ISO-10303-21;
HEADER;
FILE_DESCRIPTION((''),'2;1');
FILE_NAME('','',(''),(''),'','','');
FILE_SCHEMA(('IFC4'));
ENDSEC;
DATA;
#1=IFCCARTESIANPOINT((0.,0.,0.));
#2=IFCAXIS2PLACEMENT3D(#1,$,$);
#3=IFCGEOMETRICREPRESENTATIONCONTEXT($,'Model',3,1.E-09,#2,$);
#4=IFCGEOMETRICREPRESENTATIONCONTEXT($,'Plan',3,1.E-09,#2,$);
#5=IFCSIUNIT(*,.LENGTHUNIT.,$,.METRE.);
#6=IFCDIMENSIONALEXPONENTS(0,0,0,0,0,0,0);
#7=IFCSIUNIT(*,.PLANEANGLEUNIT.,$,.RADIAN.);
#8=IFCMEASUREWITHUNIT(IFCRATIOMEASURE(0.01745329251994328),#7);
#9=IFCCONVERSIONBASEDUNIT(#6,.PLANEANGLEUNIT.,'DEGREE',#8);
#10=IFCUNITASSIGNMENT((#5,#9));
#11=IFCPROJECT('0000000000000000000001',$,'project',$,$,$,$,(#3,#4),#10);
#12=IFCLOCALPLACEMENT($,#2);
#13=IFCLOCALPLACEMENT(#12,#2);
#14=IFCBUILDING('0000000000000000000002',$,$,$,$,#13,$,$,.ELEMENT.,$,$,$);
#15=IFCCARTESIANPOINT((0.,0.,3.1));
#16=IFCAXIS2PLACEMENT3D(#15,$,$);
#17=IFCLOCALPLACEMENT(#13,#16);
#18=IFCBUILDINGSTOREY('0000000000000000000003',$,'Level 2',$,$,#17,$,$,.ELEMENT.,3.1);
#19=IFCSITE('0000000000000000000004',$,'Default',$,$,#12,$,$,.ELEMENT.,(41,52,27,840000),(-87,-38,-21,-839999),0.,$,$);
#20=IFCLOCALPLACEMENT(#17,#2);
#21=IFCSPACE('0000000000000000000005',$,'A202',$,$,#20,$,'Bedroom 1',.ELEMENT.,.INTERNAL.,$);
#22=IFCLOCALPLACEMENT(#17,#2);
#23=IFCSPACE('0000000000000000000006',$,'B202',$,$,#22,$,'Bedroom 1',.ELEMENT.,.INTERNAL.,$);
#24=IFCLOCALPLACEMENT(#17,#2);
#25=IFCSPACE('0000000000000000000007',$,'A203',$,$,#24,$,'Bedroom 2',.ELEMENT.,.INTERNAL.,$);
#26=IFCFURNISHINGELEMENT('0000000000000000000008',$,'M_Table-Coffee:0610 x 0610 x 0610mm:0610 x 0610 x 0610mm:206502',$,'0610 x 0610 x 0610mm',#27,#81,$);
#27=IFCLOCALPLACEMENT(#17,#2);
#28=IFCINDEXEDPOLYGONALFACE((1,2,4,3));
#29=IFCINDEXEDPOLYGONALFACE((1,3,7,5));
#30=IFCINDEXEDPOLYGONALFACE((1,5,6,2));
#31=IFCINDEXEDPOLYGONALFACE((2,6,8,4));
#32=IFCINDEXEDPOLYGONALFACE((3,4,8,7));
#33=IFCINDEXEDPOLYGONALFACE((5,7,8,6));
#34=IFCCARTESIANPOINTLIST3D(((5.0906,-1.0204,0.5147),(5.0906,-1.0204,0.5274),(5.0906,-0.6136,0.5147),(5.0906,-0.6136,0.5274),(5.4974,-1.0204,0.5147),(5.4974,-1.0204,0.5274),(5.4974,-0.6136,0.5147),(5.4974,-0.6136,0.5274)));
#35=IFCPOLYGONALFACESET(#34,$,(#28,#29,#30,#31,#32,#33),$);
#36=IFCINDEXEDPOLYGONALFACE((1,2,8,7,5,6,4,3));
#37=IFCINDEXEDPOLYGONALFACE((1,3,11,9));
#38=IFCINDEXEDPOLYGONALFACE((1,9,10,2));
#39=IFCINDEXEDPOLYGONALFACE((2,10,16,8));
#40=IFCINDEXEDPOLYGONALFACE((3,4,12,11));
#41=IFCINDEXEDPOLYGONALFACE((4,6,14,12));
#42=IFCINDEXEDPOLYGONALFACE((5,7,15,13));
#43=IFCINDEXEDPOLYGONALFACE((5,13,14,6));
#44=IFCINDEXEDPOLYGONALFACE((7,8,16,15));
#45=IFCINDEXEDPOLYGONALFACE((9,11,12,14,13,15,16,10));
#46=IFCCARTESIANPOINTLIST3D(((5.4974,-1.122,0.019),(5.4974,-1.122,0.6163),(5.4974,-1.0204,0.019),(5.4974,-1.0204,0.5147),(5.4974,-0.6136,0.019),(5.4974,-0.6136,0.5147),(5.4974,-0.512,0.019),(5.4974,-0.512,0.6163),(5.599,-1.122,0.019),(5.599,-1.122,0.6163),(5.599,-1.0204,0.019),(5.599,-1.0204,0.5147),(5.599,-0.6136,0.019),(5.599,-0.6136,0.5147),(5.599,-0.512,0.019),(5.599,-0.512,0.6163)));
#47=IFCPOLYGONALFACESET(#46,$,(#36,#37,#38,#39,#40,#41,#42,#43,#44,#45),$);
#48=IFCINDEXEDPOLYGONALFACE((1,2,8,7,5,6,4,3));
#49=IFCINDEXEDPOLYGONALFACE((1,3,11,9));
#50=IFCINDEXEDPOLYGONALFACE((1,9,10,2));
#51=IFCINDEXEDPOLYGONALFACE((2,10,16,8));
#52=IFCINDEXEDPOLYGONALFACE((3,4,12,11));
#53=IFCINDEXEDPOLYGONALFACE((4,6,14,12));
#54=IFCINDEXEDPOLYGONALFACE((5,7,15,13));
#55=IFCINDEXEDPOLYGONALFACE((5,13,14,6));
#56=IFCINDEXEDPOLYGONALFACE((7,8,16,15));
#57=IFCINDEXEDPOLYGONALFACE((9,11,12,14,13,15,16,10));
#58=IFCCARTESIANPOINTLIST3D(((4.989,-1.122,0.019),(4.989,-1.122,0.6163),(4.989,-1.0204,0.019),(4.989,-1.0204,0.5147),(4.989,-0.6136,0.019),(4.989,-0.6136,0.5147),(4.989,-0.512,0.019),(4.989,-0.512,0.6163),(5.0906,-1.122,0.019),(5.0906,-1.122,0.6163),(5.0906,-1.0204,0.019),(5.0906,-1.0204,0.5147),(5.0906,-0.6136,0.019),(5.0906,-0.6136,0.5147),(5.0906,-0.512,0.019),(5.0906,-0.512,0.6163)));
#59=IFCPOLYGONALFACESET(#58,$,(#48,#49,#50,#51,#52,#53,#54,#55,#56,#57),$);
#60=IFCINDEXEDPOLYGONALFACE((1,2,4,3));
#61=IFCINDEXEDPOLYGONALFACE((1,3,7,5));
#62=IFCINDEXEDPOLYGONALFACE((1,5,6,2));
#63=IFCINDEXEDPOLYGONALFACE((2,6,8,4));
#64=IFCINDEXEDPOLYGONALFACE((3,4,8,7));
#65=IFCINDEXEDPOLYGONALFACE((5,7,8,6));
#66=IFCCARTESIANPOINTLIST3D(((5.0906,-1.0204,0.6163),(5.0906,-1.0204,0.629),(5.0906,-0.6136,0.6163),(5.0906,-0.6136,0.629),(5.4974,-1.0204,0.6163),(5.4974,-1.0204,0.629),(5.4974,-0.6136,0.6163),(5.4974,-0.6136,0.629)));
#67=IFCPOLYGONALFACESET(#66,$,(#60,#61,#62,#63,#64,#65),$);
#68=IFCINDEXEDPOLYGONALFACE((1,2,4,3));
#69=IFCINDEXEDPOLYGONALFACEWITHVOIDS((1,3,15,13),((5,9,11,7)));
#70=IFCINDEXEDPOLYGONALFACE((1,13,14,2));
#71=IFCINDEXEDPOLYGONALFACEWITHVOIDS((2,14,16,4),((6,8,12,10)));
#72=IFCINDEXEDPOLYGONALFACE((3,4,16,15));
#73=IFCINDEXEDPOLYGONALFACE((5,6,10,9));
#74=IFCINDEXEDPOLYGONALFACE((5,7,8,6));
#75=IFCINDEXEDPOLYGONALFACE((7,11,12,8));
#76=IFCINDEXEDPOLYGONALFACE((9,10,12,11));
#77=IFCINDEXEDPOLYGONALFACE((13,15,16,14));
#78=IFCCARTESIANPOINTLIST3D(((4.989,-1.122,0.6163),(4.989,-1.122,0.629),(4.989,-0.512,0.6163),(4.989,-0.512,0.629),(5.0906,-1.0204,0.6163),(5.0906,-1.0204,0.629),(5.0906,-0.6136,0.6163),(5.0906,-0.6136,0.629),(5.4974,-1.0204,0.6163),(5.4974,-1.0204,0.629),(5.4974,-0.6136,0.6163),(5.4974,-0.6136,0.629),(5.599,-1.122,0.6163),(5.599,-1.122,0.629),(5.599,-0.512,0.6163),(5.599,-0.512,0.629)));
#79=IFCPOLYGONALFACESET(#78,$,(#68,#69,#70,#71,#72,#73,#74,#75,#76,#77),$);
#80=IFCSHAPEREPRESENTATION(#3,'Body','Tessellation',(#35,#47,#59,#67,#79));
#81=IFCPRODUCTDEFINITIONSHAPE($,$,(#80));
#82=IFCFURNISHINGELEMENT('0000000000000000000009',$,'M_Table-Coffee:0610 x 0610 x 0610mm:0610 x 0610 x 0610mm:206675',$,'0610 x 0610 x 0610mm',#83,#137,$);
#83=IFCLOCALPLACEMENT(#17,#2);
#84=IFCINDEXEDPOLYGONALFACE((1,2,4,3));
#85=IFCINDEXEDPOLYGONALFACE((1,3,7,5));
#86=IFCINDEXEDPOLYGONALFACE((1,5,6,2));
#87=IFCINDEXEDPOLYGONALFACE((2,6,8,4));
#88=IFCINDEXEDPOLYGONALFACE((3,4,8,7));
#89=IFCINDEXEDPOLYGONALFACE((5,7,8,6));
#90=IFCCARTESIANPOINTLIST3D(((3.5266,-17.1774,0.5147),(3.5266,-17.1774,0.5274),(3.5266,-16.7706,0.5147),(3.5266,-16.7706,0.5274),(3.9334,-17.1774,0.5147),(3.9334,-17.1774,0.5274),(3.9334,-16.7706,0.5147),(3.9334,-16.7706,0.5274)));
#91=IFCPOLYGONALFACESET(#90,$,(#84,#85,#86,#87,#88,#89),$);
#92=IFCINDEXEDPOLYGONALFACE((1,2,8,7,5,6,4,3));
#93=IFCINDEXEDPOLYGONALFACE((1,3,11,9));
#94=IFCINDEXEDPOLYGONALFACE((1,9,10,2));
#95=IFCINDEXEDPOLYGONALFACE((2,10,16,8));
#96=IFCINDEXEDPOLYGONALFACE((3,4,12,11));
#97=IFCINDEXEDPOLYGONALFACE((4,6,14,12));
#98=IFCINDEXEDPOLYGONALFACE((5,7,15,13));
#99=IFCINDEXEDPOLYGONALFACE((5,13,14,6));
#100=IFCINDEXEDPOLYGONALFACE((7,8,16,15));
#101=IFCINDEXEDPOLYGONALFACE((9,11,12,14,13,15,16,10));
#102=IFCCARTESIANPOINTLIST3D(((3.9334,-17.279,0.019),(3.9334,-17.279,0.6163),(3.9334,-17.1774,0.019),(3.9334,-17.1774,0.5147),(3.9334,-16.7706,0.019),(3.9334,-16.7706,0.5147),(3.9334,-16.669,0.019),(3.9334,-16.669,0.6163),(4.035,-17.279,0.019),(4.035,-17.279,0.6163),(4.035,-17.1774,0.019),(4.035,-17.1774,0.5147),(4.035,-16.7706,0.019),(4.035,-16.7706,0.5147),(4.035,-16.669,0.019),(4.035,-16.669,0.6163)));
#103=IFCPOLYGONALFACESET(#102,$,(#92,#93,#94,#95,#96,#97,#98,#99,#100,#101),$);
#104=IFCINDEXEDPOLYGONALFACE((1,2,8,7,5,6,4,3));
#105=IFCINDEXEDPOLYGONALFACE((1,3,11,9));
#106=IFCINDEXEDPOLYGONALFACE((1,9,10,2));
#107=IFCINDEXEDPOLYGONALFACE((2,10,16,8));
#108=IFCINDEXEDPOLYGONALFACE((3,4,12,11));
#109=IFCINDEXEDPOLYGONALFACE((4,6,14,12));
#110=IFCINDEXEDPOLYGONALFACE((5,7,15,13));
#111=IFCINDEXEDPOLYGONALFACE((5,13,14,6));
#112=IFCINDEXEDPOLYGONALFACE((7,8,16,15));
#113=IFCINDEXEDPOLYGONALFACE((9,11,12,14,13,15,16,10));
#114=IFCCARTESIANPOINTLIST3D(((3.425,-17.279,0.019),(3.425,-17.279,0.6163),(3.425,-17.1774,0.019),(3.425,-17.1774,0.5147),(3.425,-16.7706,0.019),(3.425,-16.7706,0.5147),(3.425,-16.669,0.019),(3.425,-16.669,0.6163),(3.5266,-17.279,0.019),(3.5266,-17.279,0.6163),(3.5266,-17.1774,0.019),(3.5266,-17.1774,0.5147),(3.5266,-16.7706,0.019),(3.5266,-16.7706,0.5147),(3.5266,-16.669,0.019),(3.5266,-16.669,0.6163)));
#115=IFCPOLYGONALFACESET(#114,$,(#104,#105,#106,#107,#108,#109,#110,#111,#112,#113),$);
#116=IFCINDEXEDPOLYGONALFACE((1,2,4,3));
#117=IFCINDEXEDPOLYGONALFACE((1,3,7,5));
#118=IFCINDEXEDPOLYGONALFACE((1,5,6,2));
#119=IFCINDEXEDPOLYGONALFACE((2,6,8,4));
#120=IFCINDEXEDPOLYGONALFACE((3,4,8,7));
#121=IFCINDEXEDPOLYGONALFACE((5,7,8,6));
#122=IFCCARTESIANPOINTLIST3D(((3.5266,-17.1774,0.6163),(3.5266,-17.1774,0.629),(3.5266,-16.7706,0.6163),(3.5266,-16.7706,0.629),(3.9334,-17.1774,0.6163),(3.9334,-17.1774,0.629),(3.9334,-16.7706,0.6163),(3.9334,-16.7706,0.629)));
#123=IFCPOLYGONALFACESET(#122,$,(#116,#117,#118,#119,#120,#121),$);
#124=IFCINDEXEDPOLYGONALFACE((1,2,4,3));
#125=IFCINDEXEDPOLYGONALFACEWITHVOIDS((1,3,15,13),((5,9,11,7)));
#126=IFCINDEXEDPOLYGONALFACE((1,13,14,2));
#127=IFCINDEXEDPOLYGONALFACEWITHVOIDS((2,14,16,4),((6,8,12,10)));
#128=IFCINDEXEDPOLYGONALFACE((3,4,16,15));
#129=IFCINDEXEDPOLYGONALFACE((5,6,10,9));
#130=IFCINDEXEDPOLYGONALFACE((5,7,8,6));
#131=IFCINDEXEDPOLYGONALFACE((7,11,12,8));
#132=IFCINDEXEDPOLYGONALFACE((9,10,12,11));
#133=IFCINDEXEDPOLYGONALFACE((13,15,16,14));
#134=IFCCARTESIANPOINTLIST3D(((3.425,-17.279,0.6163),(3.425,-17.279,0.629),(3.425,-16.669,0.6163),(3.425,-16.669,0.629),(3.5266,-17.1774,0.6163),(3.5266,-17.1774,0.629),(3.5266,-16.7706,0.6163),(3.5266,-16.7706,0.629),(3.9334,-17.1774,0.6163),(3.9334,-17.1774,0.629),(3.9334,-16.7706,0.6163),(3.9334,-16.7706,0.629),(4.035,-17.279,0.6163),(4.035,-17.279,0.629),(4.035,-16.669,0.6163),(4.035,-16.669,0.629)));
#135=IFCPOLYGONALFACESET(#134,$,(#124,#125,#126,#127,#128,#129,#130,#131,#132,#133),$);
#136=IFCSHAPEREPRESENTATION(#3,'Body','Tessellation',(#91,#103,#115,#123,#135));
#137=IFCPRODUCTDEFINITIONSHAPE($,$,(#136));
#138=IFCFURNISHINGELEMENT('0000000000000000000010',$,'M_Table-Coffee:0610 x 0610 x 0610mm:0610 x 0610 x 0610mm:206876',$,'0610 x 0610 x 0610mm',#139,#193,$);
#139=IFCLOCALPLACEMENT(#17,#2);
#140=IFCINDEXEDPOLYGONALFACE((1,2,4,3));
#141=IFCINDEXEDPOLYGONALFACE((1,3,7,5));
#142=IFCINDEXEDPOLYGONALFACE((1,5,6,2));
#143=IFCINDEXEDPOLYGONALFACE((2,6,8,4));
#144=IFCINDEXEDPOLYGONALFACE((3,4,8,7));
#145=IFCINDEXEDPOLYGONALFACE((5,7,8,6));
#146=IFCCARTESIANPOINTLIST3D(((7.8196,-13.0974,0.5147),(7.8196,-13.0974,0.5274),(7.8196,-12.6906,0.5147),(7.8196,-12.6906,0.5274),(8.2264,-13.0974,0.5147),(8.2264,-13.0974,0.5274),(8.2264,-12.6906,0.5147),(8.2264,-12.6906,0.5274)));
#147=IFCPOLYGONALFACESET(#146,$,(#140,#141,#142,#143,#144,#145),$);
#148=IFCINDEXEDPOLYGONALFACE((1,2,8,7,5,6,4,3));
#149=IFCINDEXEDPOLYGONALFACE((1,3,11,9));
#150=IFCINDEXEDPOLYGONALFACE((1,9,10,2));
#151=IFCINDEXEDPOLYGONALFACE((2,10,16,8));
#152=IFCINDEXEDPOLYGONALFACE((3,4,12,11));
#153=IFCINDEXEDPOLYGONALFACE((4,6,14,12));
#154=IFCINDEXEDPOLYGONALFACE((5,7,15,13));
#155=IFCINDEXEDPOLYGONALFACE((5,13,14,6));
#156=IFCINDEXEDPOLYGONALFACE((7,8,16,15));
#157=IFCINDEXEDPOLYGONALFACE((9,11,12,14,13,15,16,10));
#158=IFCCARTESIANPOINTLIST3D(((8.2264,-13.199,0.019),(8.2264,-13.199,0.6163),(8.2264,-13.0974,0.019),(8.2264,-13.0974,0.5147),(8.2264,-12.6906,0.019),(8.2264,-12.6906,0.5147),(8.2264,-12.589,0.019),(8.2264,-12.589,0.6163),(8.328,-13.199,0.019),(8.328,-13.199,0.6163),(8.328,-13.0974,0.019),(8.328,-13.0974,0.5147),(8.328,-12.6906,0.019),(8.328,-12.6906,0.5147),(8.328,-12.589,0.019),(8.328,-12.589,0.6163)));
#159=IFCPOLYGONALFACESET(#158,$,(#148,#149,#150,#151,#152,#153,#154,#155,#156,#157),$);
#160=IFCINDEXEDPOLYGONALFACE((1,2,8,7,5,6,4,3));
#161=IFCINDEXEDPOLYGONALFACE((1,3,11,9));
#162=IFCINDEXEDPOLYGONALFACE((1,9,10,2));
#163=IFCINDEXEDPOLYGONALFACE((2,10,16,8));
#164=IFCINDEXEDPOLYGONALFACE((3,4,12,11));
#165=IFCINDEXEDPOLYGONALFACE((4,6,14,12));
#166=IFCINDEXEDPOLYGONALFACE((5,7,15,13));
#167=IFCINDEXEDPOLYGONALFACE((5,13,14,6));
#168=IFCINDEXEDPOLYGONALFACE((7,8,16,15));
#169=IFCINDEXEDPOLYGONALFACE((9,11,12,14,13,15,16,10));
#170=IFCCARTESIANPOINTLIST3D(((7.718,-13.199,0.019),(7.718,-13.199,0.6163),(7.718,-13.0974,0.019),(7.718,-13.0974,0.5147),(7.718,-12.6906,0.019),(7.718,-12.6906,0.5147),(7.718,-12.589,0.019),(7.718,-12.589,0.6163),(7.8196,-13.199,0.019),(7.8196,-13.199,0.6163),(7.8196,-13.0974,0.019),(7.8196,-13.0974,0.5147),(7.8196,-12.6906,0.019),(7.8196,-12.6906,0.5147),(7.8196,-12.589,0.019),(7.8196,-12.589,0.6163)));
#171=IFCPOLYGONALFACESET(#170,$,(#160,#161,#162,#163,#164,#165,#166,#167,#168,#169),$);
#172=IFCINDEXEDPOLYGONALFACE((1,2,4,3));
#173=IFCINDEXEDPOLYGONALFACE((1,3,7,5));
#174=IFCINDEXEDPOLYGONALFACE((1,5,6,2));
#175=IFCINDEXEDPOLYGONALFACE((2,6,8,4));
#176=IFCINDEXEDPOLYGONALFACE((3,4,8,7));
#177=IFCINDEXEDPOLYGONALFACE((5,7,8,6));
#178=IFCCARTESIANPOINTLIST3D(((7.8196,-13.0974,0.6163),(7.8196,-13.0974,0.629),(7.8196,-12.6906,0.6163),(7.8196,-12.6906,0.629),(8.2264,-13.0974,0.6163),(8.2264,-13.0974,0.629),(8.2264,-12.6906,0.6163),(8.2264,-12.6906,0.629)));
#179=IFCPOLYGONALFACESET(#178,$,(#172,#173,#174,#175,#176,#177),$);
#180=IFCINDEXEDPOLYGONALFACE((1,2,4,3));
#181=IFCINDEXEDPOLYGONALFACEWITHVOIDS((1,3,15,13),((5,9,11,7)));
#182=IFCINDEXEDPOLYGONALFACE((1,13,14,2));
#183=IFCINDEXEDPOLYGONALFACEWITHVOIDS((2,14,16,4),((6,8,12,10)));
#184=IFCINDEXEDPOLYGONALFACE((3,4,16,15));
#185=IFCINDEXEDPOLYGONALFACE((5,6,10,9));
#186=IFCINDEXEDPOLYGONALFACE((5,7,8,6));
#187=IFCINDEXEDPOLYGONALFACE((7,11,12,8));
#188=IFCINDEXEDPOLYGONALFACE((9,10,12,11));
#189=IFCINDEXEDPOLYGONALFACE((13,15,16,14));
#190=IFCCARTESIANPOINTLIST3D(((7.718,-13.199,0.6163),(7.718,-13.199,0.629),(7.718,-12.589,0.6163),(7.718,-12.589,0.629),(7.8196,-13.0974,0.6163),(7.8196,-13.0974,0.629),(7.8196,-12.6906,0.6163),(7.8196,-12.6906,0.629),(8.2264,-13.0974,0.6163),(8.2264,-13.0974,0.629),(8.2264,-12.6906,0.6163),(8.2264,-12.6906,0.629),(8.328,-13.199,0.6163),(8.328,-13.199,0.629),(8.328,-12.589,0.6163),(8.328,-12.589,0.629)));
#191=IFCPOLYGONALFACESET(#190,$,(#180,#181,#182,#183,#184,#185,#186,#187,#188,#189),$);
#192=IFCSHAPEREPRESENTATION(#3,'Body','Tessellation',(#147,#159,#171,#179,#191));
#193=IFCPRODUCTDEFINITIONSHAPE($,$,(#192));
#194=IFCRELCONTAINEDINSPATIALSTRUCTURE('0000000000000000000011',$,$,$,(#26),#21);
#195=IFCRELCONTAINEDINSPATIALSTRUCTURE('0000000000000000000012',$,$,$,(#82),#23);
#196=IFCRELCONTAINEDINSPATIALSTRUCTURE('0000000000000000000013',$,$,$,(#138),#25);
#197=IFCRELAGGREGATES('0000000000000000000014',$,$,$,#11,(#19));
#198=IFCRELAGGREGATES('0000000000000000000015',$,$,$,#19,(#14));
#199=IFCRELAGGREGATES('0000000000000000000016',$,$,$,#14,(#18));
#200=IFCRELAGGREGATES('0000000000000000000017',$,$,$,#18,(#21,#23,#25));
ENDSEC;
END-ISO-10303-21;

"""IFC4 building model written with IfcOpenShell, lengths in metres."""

from ifc_helpers import new_model, entity, si_unit, converted_unit, frame, origin, origin_2d_with_axis, place, context, project, spatial, polyline, rectangle, outline, extrude, source, transform, mapped, element, save


model = new_model("IFC4")

# Units and contexts
model_context = context("Model", 3, precision=1e-09, world=origin())
plan_context = context("Plan", 3, precision=1e-09, world=origin())
ifc_project = project(units=[si_unit("LENGTHUNIT", "METRE"), converted_unit("PLANEANGLEUNIT", "DEGREE", entity("IfcRatioMeasure", 0.01745329251994328), si_unit("PLANEANGLEUNIT", "RADIAN"), dimensions=[0, 0, 0, 0, 0, 0, 0])], contexts=[model_context, plan_context])

# Site, building, storey
site_placement = place(None, origin())
site = spatial("IfcSite", under=ifc_project, at=site_placement, Name="Default", CompositionType="ELEMENT", RefLatitude=(41, 52, 27, 840000), RefLongitude=(-87, -38, -21, -839999), RefElevation=0.0)
building_placement = place(site_placement, origin())
building = spatial("IfcBuilding", under=site, at=building_placement, CompositionType="ELEMENT")
storey_placement = place(building_placement, frame((0.0, 0.0, 3.1)))
storey = spatial("IfcBuildingStorey", under=building, at=storey_placement, Name="Level 2", CompositionType="ELEMENT", Elevation=3.1)

# Shared definitions
shared_shape = source(origin(), model_context, "Body", "SweptSolid", [
    extrude(rectangle(XDim=0.4068, YDim=0.4068, at=origin_2d_with_axis()), frame((0.0183, 0.0952, 0.4957), z_axis=(0.0, 0.0, 1.0), x_axis=(-1.0, 0.0, 0.0)), (0.0, 0.0, 1.0), 0.0127),
    extrude(outline(polyline([(-0.2732, -0.305), (0.324, -0.305), (0.324, 0.305), (-0.2732, 0.305), (-0.2732, 0.2034), (0.2225, 0.2034), (0.2225, -0.2034), (-0.2732, -0.2034), (-0.2732, -0.305)])), frame((0.2217, 0.0952, 0.2732), z_axis=(1.0, 0.0, 0.0), x_axis=(0.0, 0.0, 1.0)), (0.0, 0.0, 1.0), 0.1016),
    extrude(outline(polyline([(-0.305, -0.3241), (0.305, -0.3241), (0.305, 0.2733), (0.2034, 0.2733), (0.2034, -0.2224), (-0.2034, -0.2224), (-0.2034, 0.2733), (-0.305, 0.2733), (-0.305, -0.3241)])), frame((-0.2867, 0.0952, 0.2733), z_axis=(1.0, 0.0, 0.0), x_axis=(0.0, -1.0, 0.0)), (0.0, 0.0, 1.0), 0.1016),
    extrude(rectangle(XDim=0.4068, YDim=0.4068, at=origin_2d_with_axis()), frame((0.0183, 0.0952, 0.5973), z_axis=(0.0, 0.0, 1.0), x_axis=(-1.0, 0.0, 0.0)), (0.0, 0.0, 1.0), 0.0127),
    extrude(outline(polyline([(-0.305, -0.305), (0.305, -0.305), (0.305, 0.305), (-0.305, 0.305), (-0.305, -0.305)]), holes=[polyline([(-0.2034, -0.2034), (-0.2034, 0.2034), (0.2034, 0.2034), (0.2034, -0.2034), (-0.2034, -0.2034)])]), frame((0.0183, 0.0952, 0.5973), z_axis=(0.0, 0.0, 1.0), x_axis=(-1.0, 0.0, 0.0)), (0.0, 0.0, 1.0), 0.0127),
])

# Shared definitions
space_1_placement = place(storey_placement, origin())
space_1 = spatial("IfcSpace", under=storey, at=space_1_placement, Name="A202", LongName="Bedroom 1", CompositionType="ELEMENT", PredefinedType="INTERNAL")

# Furnishing element
furnishing_1_placement = place(space_1_placement, frame((5.2757, -0.9122, 0.019)))
element("IfcFurnishingElement", 1, at=furnishing_1_placement, inside=space_1, Name="M_Table-Coffee:0610 x 0610 x 0610mm:0610 x 0610 x 0610mm:206502", ObjectType="0610 x 0610 x 0610mm", context=model_context, shape_type="MappedRepresentation", body=[
    mapped(shared_shape, transform((0.0, 0.0, 0.0), scale=1.0)),
])

# Shared definitions
space_2_placement = place(storey_placement, origin())
space_2 = spatial("IfcSpace", under=storey, at=space_2_placement, Name="B202", LongName="Bedroom 1", CompositionType="ELEMENT", PredefinedType="INTERNAL")

# Furnishing element
furnishing_2_placement = place(space_2_placement, frame((3.7117, -17.0692, 0.019)))
element("IfcFurnishingElement", 2, at=furnishing_2_placement, inside=space_2, Name="M_Table-Coffee:0610 x 0610 x 0610mm:0610 x 0610 x 0610mm:206675", ObjectType="0610 x 0610 x 0610mm", context=model_context, shape_type="MappedRepresentation", body=[
    mapped(shared_shape, transform((0.0, 0.0, 0.0), scale=1.0)),
])

# Shared definitions
space_3_placement = place(storey_placement, origin())
space_3 = spatial("IfcSpace", under=storey, at=space_3_placement, Name="A203", LongName="Bedroom 2", CompositionType="ELEMENT", PredefinedType="INTERNAL")

# Furnishing element
furnishing_3_placement = place(space_3_placement, frame((8.0047, -12.9892, 0.019)))
element("IfcFurnishingElement", 3, at=furnishing_3_placement, inside=space_3, Name="M_Table-Coffee:0610 x 0610 x 0610mm:0610 x 0610 x 0610mm:206876", ObjectType="0610 x 0610 x 0610mm", context=model_context, shape_type="MappedRepresentation", body=[
    mapped(shared_shape, transform((0.0, 0.0, 0.0), scale=1.0)),
])

save(model, "model.ifc")
